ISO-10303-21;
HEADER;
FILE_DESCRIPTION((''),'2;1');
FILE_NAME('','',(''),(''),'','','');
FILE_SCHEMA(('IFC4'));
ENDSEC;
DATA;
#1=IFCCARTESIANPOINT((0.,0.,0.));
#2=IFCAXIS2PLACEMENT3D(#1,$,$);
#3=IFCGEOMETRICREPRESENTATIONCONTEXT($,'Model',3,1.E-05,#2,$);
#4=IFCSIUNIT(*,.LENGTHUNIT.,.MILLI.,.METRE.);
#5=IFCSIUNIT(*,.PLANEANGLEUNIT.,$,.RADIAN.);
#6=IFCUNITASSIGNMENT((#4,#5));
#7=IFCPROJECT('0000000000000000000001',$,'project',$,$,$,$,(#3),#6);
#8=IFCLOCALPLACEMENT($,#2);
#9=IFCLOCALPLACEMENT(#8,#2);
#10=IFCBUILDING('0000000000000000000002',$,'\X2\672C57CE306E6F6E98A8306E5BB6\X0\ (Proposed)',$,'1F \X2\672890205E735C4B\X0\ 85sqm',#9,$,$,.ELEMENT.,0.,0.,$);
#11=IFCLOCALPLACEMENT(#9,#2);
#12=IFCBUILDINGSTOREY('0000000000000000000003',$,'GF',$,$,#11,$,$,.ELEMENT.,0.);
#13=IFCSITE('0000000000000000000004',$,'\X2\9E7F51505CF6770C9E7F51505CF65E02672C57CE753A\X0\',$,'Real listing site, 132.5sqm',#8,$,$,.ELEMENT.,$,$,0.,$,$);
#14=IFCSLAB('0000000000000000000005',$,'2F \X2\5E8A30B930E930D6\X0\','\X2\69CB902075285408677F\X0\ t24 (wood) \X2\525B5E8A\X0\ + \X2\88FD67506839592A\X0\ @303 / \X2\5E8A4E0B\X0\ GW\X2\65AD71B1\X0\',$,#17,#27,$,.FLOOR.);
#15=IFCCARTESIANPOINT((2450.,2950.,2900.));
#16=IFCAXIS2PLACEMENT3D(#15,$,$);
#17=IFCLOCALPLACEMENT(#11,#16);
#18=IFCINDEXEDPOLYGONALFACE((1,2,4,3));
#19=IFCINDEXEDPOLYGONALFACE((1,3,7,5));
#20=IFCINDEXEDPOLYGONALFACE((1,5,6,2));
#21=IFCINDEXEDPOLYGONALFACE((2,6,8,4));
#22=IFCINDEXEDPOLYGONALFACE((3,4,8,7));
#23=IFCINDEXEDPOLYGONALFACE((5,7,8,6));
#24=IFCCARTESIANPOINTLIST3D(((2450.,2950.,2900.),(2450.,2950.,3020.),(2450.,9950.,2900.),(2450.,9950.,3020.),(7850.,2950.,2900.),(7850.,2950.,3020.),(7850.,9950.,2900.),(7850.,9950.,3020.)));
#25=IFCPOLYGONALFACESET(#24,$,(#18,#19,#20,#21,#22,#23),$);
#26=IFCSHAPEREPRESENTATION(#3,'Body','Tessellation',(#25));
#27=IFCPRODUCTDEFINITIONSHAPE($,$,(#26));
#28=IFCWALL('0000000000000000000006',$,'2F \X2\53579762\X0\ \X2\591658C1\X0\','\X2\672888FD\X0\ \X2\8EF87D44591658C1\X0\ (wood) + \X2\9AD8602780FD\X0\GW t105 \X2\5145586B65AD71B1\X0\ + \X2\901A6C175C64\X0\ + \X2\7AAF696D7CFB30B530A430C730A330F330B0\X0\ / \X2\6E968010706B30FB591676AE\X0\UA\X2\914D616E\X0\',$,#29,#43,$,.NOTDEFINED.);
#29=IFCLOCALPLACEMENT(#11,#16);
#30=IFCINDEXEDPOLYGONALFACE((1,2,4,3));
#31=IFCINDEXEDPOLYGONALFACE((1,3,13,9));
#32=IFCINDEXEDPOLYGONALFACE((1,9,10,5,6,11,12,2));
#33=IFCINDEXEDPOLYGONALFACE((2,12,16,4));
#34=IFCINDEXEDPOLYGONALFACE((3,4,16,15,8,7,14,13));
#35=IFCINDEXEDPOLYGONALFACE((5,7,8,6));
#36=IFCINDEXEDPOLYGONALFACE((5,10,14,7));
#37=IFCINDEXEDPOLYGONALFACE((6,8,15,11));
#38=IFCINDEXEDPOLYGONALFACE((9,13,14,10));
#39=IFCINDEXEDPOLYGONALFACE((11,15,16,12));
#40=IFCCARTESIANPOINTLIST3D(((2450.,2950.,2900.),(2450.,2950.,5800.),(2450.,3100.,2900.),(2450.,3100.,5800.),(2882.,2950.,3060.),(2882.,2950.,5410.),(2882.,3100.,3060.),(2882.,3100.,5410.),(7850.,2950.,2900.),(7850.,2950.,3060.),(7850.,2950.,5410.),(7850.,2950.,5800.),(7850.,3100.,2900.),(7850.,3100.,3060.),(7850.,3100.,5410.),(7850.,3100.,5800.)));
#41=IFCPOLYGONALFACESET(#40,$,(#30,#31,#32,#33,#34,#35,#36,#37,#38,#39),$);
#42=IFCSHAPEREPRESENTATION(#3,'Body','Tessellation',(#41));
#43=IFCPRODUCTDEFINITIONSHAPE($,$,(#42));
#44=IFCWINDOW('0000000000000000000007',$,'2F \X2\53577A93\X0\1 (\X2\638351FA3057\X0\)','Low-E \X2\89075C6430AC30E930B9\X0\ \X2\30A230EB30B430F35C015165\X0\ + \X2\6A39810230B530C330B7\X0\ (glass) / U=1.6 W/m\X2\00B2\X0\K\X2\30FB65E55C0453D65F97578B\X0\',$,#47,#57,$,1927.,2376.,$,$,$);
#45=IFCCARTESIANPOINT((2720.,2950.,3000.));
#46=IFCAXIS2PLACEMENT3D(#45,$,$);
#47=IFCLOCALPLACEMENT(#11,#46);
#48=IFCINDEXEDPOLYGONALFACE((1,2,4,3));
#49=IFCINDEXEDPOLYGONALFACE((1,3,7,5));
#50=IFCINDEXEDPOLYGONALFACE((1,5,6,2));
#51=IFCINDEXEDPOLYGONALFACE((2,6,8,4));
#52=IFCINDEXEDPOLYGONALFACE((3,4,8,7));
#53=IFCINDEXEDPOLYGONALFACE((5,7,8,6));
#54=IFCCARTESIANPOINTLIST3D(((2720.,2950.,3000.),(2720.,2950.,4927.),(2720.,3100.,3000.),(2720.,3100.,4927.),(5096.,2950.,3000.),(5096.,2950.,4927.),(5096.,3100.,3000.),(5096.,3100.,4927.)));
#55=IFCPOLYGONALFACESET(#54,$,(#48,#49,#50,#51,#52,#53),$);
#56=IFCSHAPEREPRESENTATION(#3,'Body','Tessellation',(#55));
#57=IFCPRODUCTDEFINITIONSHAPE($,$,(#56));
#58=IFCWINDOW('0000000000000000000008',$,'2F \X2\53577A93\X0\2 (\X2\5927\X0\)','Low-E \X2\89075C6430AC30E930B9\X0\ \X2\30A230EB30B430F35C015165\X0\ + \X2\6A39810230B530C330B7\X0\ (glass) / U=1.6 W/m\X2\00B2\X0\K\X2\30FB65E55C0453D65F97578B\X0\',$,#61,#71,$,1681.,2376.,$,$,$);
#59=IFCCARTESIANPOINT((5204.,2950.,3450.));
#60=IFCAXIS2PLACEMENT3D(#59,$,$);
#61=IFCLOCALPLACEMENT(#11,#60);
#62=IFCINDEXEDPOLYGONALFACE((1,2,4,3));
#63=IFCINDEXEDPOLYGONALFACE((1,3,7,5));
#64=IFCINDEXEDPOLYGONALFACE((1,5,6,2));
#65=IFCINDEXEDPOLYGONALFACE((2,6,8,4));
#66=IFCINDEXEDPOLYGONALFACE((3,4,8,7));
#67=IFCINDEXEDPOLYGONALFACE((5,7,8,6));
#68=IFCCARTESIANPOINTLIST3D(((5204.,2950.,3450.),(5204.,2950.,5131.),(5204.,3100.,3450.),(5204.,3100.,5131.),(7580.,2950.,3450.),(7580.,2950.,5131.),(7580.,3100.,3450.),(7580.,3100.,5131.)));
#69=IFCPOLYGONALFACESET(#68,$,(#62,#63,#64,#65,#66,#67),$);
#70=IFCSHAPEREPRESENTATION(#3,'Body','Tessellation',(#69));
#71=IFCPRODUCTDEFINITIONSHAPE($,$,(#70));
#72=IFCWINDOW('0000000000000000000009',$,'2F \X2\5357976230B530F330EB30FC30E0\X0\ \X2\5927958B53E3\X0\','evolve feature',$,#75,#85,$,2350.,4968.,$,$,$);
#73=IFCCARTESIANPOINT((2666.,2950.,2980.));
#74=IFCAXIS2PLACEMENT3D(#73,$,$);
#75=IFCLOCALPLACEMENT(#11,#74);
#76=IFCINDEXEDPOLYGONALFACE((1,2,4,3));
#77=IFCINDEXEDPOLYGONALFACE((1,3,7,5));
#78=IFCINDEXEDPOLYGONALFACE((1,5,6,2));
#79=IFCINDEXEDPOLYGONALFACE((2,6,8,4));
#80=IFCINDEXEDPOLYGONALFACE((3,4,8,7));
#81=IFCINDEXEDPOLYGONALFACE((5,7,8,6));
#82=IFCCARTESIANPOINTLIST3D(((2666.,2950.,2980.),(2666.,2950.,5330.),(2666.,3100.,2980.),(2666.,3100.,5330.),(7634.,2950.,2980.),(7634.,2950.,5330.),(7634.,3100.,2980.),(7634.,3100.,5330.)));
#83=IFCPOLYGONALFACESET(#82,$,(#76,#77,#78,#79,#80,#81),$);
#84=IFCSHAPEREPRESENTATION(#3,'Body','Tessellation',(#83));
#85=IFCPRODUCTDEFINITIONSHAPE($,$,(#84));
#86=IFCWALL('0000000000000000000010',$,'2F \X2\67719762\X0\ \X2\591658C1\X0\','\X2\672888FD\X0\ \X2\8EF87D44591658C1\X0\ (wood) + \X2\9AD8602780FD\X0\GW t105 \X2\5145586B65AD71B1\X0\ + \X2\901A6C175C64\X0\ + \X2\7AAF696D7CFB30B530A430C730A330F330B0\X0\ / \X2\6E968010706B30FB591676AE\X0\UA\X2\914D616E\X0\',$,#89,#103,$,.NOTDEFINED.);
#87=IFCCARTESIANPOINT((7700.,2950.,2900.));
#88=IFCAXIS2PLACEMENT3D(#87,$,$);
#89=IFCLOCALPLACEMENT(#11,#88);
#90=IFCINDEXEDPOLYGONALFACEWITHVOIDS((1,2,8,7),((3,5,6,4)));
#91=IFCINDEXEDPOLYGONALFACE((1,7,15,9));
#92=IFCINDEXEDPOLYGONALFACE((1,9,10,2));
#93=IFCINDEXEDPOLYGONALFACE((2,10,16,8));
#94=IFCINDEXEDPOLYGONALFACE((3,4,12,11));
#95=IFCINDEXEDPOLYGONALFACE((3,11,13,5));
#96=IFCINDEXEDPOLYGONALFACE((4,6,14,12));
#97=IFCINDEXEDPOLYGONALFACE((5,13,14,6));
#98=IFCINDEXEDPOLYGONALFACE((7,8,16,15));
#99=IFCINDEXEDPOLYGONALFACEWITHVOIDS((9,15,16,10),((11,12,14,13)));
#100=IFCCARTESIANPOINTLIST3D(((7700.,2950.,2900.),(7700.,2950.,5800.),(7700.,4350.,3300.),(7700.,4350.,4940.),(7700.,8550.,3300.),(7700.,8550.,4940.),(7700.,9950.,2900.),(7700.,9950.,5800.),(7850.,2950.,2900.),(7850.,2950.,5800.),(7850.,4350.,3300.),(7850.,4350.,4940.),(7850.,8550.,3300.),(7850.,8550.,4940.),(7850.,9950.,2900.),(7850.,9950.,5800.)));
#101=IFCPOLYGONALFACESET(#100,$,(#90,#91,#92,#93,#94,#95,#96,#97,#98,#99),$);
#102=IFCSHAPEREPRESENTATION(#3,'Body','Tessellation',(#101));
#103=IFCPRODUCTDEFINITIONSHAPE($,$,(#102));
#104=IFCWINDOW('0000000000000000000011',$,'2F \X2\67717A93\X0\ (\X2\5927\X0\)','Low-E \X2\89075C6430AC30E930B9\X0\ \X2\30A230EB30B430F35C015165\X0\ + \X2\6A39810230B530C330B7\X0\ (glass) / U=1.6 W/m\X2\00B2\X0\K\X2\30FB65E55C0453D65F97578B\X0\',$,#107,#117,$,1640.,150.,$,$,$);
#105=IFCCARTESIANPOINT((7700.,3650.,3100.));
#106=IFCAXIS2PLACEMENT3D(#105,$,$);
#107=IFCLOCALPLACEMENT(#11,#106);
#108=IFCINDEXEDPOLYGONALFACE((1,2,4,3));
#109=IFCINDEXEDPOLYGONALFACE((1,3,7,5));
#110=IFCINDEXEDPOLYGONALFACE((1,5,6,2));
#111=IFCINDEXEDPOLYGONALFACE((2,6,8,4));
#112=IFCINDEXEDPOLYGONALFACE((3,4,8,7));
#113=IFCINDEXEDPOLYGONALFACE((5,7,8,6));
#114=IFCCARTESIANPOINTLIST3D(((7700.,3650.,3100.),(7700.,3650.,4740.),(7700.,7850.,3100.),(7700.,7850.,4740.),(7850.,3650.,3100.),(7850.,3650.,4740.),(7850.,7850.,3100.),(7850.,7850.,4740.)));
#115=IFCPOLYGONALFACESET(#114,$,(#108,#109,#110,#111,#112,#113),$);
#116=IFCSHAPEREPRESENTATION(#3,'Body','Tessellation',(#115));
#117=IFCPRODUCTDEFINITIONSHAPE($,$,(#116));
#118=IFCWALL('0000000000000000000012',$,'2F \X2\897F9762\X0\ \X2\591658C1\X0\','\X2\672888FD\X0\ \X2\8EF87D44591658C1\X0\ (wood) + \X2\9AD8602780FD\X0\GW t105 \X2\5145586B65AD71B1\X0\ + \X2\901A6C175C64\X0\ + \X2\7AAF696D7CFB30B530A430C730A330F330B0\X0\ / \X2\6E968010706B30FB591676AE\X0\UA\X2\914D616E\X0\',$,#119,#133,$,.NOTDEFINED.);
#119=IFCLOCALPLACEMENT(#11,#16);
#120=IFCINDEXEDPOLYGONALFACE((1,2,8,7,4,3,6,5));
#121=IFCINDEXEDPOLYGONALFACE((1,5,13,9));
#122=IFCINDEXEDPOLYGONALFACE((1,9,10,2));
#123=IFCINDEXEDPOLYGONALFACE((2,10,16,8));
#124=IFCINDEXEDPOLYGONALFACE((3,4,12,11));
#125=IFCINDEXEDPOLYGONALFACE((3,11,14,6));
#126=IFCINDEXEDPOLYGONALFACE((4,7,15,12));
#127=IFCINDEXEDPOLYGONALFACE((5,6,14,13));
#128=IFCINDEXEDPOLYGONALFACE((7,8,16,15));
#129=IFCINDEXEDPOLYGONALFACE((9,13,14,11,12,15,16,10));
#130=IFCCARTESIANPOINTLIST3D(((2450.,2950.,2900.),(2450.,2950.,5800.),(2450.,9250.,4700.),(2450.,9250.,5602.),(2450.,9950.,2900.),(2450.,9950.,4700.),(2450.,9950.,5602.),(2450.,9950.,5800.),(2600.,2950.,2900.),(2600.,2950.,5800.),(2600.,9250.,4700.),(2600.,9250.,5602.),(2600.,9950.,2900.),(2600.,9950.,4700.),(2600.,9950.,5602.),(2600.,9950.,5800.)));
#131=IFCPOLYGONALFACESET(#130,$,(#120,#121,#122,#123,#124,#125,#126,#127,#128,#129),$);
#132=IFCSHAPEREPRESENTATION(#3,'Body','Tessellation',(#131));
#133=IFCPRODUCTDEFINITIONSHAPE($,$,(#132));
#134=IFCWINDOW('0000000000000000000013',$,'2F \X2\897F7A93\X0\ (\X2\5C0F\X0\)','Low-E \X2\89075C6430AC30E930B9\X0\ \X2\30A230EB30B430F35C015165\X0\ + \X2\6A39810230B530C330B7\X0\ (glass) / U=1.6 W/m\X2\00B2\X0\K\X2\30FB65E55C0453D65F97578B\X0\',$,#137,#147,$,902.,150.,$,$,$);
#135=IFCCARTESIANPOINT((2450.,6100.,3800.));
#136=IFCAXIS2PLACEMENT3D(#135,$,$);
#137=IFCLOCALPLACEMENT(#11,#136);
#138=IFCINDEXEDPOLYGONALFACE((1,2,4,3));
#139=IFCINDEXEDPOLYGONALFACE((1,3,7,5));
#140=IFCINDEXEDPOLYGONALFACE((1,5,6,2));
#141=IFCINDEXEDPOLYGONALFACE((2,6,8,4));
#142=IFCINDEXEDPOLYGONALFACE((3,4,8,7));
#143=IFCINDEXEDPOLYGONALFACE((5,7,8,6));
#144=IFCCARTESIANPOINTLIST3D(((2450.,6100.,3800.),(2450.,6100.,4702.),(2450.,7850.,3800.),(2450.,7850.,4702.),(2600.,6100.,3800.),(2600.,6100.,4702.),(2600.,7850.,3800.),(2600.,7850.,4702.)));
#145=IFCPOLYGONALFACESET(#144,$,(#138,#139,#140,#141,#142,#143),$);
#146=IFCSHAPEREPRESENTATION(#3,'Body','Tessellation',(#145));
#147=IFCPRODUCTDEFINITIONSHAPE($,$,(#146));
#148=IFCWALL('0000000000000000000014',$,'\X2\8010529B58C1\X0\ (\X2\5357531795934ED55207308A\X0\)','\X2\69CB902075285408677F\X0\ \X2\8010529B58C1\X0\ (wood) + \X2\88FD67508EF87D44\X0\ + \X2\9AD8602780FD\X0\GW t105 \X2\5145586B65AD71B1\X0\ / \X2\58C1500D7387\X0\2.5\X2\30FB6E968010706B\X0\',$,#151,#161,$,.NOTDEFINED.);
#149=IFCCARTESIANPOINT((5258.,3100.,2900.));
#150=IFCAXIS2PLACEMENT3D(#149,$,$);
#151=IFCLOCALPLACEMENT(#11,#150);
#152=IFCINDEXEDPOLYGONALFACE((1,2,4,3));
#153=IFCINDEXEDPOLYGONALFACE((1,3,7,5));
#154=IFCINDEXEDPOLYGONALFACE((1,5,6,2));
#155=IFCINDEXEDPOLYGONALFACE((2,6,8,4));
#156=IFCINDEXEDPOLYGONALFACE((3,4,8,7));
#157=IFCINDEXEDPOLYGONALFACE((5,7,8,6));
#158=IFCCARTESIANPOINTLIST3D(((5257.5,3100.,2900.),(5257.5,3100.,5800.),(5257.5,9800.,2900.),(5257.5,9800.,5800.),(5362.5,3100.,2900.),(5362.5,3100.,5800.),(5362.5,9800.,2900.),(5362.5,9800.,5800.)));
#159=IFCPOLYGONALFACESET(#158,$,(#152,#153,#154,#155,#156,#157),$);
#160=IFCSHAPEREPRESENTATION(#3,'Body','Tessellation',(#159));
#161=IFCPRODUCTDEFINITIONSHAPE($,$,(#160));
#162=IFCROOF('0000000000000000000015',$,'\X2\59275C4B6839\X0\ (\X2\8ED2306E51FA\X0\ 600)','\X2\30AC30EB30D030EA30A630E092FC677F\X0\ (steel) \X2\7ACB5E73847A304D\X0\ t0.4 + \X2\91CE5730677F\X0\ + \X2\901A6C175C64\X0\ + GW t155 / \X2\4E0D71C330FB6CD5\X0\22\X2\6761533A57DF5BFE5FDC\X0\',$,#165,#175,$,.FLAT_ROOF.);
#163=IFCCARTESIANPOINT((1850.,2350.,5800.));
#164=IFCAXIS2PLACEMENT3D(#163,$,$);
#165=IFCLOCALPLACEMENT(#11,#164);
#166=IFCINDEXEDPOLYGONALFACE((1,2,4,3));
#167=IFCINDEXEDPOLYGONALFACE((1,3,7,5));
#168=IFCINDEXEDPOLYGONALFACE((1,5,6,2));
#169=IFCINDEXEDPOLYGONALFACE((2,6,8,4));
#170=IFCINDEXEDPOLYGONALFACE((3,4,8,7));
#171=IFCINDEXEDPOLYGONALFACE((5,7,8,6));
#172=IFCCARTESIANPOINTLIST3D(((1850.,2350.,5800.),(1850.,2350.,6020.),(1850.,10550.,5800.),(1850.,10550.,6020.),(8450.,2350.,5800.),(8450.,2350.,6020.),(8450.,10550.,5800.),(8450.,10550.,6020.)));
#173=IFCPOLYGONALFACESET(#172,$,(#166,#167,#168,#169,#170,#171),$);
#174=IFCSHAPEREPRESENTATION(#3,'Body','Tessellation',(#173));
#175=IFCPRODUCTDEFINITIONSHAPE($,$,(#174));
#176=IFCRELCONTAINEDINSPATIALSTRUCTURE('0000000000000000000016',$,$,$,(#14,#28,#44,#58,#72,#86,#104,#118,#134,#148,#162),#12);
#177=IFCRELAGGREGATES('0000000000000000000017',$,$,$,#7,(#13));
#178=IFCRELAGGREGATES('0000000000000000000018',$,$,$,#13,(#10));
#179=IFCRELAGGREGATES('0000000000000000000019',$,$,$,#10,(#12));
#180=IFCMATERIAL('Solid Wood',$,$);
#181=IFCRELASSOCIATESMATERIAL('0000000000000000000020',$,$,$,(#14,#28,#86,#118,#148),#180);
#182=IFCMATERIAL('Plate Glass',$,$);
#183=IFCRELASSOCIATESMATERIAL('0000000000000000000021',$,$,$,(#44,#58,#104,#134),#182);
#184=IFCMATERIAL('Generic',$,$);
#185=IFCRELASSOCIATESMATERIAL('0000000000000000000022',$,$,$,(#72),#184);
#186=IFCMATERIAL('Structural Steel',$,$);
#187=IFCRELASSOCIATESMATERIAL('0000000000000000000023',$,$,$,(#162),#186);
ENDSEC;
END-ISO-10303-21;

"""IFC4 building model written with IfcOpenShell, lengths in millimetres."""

from ifc_helpers import new_model, si_unit, frame, frame_2d, origin, place, context, project, spatial, rectangle, extrude, material, element, fill, save


model = new_model("IFC4")

# Units and contexts
model_context = context("Model", 3, precision=1e-05, world=origin())
ifc_project = project(units=[si_unit("LENGTHUNIT", "METRE", prefix="MILLI"), si_unit("PLANEANGLEUNIT", "RADIAN")], contexts=[model_context])

# Site, building, storey
site_placement = place(None, origin())
site = spatial("IfcSite", under=ifc_project, at=site_placement, Name="鹿児島県鹿児島市本城町", ObjectType="Real listing site, 132.5sqm", CompositionType="ELEMENT", RefElevation=0.0)
building_placement = place(site_placement, origin())
building = spatial("IfcBuilding", under=site, at=building_placement, Name="本城の潮風の家 (Proposed)", ObjectType="1F 木造平屋 85sqm", CompositionType="ELEMENT", ElevationOfRefHeight=0.0, ElevationOfTerrain=0.0)
storey_placement = place(building_placement, origin())
storey = spatial("IfcBuildingStorey", under=building, at=storey_placement, Name="GF", CompositionType="ELEMENT", Elevation=0.0)

# Slab
ifc_material_1 = material(Name="Solid Wood")
slab_placement = place(storey_placement, frame((2450.0, 2950.0, 2900.0)))
element("IfcSlab", 1, at=slab_placement, inside=storey, material=ifc_material_1, Name="2F 床スラブ", Description="構造用合板 t24 (wood) 剛床 + 製材根太 @303 / 床下 GW断熱", PredefinedType="FLOOR", context=model_context, shape_type="SweptSolid", body=[
    extrude(rectangle(XDim=5400.0, YDim=7000.0, at=frame_2d((2700.0, 3500.0))), frame((2450.0, 2950.0, 2900.0)), (0.0, 0.0, 1.0), 120.0),
])

# Wall, openings, windows
wall_1_placement = place(storey_placement, frame((2450.0, 2950.0, 2900.0)))
wall_1 = element("IfcWall", 2, at=wall_1_placement, inside=storey, material=ifc_material_1, Name="2F 南面 外壁", Description="木製 軸組外壁 (wood) + 高性能GW t105 充填断熱 + 通気層 + 窯業系サイディング / 準耐火・外皮UA配慮", PredefinedType="NOTDEFINED", context=model_context, shape_type="SweptSolid", body=[
    extrude(rectangle(XDim=5400.0, YDim=150.0, at=frame_2d((2700.0, 75.0))), frame((2450.0, 2950.0, 2900.0)), (0.0, 0.0, 1.0), 2900.0),
])
opening_1_placement = place(storey_placement, frame((2720.0, 2950.0, 3000.0)))
opening_1 = element("IfcOpeningElement", 3, at=opening_1_placement, cuts=wall_1, PredefinedType="NOTDEFINED", context=model_context, shape_type="SweptSolid", body=[
    extrude(rectangle(XDim=2376.0, YDim=150.0, at=frame_2d((1188.0, 75.0))), frame((2720.0, 2950.0, 3000.0)), (0.0, 0.0, 1.0), 1927.0),
])
opening_2_placement = place(storey_placement, frame((5204.0, 2950.0, 3450.0)))
opening_2 = element("IfcOpeningElement", 4, at=opening_2_placement, cuts=wall_1, PredefinedType="NOTDEFINED", context=model_context, shape_type="SweptSolid", body=[
    extrude(rectangle(XDim=2376.0, YDim=150.0, at=frame_2d((1188.0, 75.0))), frame((5204.0, 2950.0, 3450.0)), (0.0, 0.0, 1.0), 1681.0),
])
opening_3_placement = place(storey_placement, frame((2666.0, 2950.0, 2980.0)))
opening_3 = element("IfcOpeningElement", 5, at=opening_3_placement, cuts=wall_1, PredefinedType="NOTDEFINED", context=model_context, shape_type="SweptSolid", body=[
    extrude(rectangle(XDim=4968.0, YDim=150.0, at=frame_2d((2484.0, 75.0))), frame((2666.0, 2950.0, 2980.0)), (0.0, 0.0, 1.0), 2350.0),
])
ifc_material_2 = material(Name="Plate Glass")
window_1_placement = place(storey_placement, frame((2720.0, 2950.0, 3000.0)))
window_1 = element("IfcWindow", 6, at=window_1_placement, inside=storey, material=ifc_material_2, Name="2F 南窓1 (掃出し)", Description="Low-E 複層ガラス アルゴン封入 + 樹脂サッシ (glass) / U=1.6 W/m²K・日射取得型", OverallHeight=1927.0, OverallWidth=2376.0, context=model_context, shape_type="SweptSolid", body=[
    extrude(rectangle(XDim=2376.0, YDim=150.0, at=frame_2d((1188.0, 75.0))), frame((2720.0, 2950.0, 3000.0)), (0.0, 0.0, 1.0), 1927.0),
])
fill(opening_1, window_1)
window_2_placement = place(storey_placement, frame((5204.0, 2950.0, 3450.0)))
window_2 = element("IfcWindow", 7, at=window_2_placement, inside=storey, material=ifc_material_2, Name="2F 南窓2 (大)", Description="Low-E 複層ガラス アルゴン封入 + 樹脂サッシ (glass) / U=1.6 W/m²K・日射取得型", OverallHeight=1681.0, OverallWidth=2376.0, context=model_context, shape_type="SweptSolid", body=[
    extrude(rectangle(XDim=2376.0, YDim=150.0, at=frame_2d((1188.0, 75.0))), frame((5204.0, 2950.0, 3450.0)), (0.0, 0.0, 1.0), 1681.0),
])
fill(opening_2, window_2)
ifc_material_3 = material(Name="Generic")
window_3_placement = place(storey_placement, frame((2666.0, 2950.0, 2980.0)))
window_3 = element("IfcWindow", 8, at=window_3_placement, inside=storey, material=ifc_material_3, Name="2F 南面サンルーム 大開口", Description="evolve feature", OverallHeight=2350.0, OverallWidth=4968.0, context=model_context, shape_type="SweptSolid", body=[
    extrude(rectangle(XDim=4968.0, YDim=150.0, at=frame_2d((2484.0, 75.0))), frame((2666.0, 2950.0, 2980.0)), (0.0, 0.0, 1.0), 2350.0),
])
fill(opening_3, window_3)

# Walls, openings, windows
wall_2_placement = place(storey_placement, frame((7700.0, 2950.0, 2900.0)))
wall_2 = element("IfcWall", 9, at=wall_2_placement, inside=storey, material=ifc_material_1, Name="2F 東面 外壁", Description="木製 軸組外壁 (wood) + 高性能GW t105 充填断熱 + 通気層 + 窯業系サイディング / 準耐火・外皮UA配慮", PredefinedType="NOTDEFINED", context=model_context, shape_type="SweptSolid", body=[
    extrude(rectangle(XDim=150.0, YDim=7000.0, at=frame_2d((75.0, 3500.0))), frame((7700.0, 2950.0, 2900.0)), (0.0, 0.0, 1.0), 2900.0),
])
opening_4_placement = place(storey_placement, frame((7700.0, 3650.0, 3100.0)))
opening_4 = element("IfcOpeningElement", 10, at=opening_4_placement, cuts=wall_2, PredefinedType="NOTDEFINED", context=model_context, shape_type="SweptSolid", body=[
    extrude(rectangle(XDim=150.0, YDim=4200.0, at=frame_2d((75.0, 2100.0))), frame((7700.0, 3650.0, 3100.0)), (0.0, 0.0, 1.0), 1640.0),
])
window_4_placement = place(storey_placement, frame((7700.0, 3650.0, 3100.0)))
window_4 = element("IfcWindow", 11, at=window_4_placement, inside=storey, material=ifc_material_2, Name="2F 東窓 (大)", Description="Low-E 複層ガラス アルゴン封入 + 樹脂サッシ (glass) / U=1.6 W/m²K・日射取得型", OverallHeight=1640.0, OverallWidth=150.0, context=model_context, shape_type="SweptSolid", body=[
    extrude(rectangle(XDim=150.0, YDim=4200.0, at=frame_2d((75.0, 2100.0))), frame((7700.0, 3650.0, 3100.0)), (0.0, 0.0, 1.0), 1640.0),
])
fill(opening_4, window_4)
wall_3_placement = place(storey_placement, frame((2450.0, 2950.0, 2900.0)))
wall_3 = element("IfcWall", 12, at=wall_3_placement, inside=storey, material=ifc_material_1, Name="2F 西面 外壁", Description="木製 軸組外壁 (wood) + 高性能GW t105 充填断熱 + 通気層 + 窯業系サイディング / 準耐火・外皮UA配慮", PredefinedType="NOTDEFINED", context=model_context, shape_type="SweptSolid", body=[
    extrude(rectangle(XDim=150.0, YDim=7000.0, at=frame_2d((75.0, 3500.0))), frame((2450.0, 2950.0, 2900.0)), (0.0, 0.0, 1.0), 2900.0),
])
opening_5_placement = place(storey_placement, frame((2450.0, 6100.0, 3800.0)))
opening_5 = element("IfcOpeningElement", 13, at=opening_5_placement, cuts=wall_3, PredefinedType="NOTDEFINED", context=model_context, shape_type="SweptSolid", body=[
    extrude(rectangle(XDim=150.0, YDim=1750.0, at=frame_2d((75.0, 875.0))), frame((2450.0, 6100.0, 3800.0)), (0.0, 0.0, 1.0), 902.0),
])
window_5_placement = place(storey_placement, frame((2450.0, 6100.0, 3800.0)))
window_5 = element("IfcWindow", 14, at=window_5_placement, inside=storey, material=ifc_material_2, Name="2F 西窓 (小)", Description="Low-E 複層ガラス アルゴン封入 + 樹脂サッシ (glass) / U=1.6 W/m²K・日射取得型", OverallHeight=902.0, OverallWidth=150.0, context=model_context, shape_type="SweptSolid", body=[
    extrude(rectangle(XDim=150.0, YDim=1750.0, at=frame_2d((75.0, 875.0))), frame((2450.0, 6100.0, 3800.0)), (0.0, 0.0, 1.0), 902.0),
])
fill(opening_5, window_5)

# Wall
wall_4_placement = place(storey_placement, frame((5258.0, 3100.0, 2900.0)))
element("IfcWall", 15, at=wall_4_placement, inside=storey, material=ifc_material_1, Name="耐力壁 (南北間仕切り)", Description="構造用合板 耐力壁 (wood) + 製材軸組 + 高性能GW t105 充填断熱 / 壁倍率2.5・準耐火", PredefinedType="NOTDEFINED", context=model_context, shape_type="SweptSolid", body=[
    extrude(rectangle(XDim=105.0, YDim=6700.0, at=frame_2d((52.0, 3350.0))), frame((5258.0, 3100.0, 2900.0)), (0.0, 0.0, 1.0), 2900.0),
])

# Roof
ifc_material_4 = material(Name="Structural Steel")
roof_1_placement = place(storey_placement, frame((1850.0, 2350.0, 5800.0)))
element("IfcRoof", 16, at=roof_1_placement, inside=storey, material=ifc_material_4, Name="大屋根 (軒の出 600)", Description="ガルバリウム鋼板 (steel) 立平葺き t0.4 + 野地板 + 通気層 + GW t155 / 不燃・法22条区域対応", PredefinedType="FLAT_ROOF", context=model_context, shape_type="SweptSolid", body=[
    extrude(rectangle(XDim=6600.0, YDim=8200.0, at=frame_2d((3300.0, 4100.0))), frame((1850.0, 2350.0, 5800.0)), (0.0, 0.0, 1.0), 220.0),
])

save(model, "model.ifc")
